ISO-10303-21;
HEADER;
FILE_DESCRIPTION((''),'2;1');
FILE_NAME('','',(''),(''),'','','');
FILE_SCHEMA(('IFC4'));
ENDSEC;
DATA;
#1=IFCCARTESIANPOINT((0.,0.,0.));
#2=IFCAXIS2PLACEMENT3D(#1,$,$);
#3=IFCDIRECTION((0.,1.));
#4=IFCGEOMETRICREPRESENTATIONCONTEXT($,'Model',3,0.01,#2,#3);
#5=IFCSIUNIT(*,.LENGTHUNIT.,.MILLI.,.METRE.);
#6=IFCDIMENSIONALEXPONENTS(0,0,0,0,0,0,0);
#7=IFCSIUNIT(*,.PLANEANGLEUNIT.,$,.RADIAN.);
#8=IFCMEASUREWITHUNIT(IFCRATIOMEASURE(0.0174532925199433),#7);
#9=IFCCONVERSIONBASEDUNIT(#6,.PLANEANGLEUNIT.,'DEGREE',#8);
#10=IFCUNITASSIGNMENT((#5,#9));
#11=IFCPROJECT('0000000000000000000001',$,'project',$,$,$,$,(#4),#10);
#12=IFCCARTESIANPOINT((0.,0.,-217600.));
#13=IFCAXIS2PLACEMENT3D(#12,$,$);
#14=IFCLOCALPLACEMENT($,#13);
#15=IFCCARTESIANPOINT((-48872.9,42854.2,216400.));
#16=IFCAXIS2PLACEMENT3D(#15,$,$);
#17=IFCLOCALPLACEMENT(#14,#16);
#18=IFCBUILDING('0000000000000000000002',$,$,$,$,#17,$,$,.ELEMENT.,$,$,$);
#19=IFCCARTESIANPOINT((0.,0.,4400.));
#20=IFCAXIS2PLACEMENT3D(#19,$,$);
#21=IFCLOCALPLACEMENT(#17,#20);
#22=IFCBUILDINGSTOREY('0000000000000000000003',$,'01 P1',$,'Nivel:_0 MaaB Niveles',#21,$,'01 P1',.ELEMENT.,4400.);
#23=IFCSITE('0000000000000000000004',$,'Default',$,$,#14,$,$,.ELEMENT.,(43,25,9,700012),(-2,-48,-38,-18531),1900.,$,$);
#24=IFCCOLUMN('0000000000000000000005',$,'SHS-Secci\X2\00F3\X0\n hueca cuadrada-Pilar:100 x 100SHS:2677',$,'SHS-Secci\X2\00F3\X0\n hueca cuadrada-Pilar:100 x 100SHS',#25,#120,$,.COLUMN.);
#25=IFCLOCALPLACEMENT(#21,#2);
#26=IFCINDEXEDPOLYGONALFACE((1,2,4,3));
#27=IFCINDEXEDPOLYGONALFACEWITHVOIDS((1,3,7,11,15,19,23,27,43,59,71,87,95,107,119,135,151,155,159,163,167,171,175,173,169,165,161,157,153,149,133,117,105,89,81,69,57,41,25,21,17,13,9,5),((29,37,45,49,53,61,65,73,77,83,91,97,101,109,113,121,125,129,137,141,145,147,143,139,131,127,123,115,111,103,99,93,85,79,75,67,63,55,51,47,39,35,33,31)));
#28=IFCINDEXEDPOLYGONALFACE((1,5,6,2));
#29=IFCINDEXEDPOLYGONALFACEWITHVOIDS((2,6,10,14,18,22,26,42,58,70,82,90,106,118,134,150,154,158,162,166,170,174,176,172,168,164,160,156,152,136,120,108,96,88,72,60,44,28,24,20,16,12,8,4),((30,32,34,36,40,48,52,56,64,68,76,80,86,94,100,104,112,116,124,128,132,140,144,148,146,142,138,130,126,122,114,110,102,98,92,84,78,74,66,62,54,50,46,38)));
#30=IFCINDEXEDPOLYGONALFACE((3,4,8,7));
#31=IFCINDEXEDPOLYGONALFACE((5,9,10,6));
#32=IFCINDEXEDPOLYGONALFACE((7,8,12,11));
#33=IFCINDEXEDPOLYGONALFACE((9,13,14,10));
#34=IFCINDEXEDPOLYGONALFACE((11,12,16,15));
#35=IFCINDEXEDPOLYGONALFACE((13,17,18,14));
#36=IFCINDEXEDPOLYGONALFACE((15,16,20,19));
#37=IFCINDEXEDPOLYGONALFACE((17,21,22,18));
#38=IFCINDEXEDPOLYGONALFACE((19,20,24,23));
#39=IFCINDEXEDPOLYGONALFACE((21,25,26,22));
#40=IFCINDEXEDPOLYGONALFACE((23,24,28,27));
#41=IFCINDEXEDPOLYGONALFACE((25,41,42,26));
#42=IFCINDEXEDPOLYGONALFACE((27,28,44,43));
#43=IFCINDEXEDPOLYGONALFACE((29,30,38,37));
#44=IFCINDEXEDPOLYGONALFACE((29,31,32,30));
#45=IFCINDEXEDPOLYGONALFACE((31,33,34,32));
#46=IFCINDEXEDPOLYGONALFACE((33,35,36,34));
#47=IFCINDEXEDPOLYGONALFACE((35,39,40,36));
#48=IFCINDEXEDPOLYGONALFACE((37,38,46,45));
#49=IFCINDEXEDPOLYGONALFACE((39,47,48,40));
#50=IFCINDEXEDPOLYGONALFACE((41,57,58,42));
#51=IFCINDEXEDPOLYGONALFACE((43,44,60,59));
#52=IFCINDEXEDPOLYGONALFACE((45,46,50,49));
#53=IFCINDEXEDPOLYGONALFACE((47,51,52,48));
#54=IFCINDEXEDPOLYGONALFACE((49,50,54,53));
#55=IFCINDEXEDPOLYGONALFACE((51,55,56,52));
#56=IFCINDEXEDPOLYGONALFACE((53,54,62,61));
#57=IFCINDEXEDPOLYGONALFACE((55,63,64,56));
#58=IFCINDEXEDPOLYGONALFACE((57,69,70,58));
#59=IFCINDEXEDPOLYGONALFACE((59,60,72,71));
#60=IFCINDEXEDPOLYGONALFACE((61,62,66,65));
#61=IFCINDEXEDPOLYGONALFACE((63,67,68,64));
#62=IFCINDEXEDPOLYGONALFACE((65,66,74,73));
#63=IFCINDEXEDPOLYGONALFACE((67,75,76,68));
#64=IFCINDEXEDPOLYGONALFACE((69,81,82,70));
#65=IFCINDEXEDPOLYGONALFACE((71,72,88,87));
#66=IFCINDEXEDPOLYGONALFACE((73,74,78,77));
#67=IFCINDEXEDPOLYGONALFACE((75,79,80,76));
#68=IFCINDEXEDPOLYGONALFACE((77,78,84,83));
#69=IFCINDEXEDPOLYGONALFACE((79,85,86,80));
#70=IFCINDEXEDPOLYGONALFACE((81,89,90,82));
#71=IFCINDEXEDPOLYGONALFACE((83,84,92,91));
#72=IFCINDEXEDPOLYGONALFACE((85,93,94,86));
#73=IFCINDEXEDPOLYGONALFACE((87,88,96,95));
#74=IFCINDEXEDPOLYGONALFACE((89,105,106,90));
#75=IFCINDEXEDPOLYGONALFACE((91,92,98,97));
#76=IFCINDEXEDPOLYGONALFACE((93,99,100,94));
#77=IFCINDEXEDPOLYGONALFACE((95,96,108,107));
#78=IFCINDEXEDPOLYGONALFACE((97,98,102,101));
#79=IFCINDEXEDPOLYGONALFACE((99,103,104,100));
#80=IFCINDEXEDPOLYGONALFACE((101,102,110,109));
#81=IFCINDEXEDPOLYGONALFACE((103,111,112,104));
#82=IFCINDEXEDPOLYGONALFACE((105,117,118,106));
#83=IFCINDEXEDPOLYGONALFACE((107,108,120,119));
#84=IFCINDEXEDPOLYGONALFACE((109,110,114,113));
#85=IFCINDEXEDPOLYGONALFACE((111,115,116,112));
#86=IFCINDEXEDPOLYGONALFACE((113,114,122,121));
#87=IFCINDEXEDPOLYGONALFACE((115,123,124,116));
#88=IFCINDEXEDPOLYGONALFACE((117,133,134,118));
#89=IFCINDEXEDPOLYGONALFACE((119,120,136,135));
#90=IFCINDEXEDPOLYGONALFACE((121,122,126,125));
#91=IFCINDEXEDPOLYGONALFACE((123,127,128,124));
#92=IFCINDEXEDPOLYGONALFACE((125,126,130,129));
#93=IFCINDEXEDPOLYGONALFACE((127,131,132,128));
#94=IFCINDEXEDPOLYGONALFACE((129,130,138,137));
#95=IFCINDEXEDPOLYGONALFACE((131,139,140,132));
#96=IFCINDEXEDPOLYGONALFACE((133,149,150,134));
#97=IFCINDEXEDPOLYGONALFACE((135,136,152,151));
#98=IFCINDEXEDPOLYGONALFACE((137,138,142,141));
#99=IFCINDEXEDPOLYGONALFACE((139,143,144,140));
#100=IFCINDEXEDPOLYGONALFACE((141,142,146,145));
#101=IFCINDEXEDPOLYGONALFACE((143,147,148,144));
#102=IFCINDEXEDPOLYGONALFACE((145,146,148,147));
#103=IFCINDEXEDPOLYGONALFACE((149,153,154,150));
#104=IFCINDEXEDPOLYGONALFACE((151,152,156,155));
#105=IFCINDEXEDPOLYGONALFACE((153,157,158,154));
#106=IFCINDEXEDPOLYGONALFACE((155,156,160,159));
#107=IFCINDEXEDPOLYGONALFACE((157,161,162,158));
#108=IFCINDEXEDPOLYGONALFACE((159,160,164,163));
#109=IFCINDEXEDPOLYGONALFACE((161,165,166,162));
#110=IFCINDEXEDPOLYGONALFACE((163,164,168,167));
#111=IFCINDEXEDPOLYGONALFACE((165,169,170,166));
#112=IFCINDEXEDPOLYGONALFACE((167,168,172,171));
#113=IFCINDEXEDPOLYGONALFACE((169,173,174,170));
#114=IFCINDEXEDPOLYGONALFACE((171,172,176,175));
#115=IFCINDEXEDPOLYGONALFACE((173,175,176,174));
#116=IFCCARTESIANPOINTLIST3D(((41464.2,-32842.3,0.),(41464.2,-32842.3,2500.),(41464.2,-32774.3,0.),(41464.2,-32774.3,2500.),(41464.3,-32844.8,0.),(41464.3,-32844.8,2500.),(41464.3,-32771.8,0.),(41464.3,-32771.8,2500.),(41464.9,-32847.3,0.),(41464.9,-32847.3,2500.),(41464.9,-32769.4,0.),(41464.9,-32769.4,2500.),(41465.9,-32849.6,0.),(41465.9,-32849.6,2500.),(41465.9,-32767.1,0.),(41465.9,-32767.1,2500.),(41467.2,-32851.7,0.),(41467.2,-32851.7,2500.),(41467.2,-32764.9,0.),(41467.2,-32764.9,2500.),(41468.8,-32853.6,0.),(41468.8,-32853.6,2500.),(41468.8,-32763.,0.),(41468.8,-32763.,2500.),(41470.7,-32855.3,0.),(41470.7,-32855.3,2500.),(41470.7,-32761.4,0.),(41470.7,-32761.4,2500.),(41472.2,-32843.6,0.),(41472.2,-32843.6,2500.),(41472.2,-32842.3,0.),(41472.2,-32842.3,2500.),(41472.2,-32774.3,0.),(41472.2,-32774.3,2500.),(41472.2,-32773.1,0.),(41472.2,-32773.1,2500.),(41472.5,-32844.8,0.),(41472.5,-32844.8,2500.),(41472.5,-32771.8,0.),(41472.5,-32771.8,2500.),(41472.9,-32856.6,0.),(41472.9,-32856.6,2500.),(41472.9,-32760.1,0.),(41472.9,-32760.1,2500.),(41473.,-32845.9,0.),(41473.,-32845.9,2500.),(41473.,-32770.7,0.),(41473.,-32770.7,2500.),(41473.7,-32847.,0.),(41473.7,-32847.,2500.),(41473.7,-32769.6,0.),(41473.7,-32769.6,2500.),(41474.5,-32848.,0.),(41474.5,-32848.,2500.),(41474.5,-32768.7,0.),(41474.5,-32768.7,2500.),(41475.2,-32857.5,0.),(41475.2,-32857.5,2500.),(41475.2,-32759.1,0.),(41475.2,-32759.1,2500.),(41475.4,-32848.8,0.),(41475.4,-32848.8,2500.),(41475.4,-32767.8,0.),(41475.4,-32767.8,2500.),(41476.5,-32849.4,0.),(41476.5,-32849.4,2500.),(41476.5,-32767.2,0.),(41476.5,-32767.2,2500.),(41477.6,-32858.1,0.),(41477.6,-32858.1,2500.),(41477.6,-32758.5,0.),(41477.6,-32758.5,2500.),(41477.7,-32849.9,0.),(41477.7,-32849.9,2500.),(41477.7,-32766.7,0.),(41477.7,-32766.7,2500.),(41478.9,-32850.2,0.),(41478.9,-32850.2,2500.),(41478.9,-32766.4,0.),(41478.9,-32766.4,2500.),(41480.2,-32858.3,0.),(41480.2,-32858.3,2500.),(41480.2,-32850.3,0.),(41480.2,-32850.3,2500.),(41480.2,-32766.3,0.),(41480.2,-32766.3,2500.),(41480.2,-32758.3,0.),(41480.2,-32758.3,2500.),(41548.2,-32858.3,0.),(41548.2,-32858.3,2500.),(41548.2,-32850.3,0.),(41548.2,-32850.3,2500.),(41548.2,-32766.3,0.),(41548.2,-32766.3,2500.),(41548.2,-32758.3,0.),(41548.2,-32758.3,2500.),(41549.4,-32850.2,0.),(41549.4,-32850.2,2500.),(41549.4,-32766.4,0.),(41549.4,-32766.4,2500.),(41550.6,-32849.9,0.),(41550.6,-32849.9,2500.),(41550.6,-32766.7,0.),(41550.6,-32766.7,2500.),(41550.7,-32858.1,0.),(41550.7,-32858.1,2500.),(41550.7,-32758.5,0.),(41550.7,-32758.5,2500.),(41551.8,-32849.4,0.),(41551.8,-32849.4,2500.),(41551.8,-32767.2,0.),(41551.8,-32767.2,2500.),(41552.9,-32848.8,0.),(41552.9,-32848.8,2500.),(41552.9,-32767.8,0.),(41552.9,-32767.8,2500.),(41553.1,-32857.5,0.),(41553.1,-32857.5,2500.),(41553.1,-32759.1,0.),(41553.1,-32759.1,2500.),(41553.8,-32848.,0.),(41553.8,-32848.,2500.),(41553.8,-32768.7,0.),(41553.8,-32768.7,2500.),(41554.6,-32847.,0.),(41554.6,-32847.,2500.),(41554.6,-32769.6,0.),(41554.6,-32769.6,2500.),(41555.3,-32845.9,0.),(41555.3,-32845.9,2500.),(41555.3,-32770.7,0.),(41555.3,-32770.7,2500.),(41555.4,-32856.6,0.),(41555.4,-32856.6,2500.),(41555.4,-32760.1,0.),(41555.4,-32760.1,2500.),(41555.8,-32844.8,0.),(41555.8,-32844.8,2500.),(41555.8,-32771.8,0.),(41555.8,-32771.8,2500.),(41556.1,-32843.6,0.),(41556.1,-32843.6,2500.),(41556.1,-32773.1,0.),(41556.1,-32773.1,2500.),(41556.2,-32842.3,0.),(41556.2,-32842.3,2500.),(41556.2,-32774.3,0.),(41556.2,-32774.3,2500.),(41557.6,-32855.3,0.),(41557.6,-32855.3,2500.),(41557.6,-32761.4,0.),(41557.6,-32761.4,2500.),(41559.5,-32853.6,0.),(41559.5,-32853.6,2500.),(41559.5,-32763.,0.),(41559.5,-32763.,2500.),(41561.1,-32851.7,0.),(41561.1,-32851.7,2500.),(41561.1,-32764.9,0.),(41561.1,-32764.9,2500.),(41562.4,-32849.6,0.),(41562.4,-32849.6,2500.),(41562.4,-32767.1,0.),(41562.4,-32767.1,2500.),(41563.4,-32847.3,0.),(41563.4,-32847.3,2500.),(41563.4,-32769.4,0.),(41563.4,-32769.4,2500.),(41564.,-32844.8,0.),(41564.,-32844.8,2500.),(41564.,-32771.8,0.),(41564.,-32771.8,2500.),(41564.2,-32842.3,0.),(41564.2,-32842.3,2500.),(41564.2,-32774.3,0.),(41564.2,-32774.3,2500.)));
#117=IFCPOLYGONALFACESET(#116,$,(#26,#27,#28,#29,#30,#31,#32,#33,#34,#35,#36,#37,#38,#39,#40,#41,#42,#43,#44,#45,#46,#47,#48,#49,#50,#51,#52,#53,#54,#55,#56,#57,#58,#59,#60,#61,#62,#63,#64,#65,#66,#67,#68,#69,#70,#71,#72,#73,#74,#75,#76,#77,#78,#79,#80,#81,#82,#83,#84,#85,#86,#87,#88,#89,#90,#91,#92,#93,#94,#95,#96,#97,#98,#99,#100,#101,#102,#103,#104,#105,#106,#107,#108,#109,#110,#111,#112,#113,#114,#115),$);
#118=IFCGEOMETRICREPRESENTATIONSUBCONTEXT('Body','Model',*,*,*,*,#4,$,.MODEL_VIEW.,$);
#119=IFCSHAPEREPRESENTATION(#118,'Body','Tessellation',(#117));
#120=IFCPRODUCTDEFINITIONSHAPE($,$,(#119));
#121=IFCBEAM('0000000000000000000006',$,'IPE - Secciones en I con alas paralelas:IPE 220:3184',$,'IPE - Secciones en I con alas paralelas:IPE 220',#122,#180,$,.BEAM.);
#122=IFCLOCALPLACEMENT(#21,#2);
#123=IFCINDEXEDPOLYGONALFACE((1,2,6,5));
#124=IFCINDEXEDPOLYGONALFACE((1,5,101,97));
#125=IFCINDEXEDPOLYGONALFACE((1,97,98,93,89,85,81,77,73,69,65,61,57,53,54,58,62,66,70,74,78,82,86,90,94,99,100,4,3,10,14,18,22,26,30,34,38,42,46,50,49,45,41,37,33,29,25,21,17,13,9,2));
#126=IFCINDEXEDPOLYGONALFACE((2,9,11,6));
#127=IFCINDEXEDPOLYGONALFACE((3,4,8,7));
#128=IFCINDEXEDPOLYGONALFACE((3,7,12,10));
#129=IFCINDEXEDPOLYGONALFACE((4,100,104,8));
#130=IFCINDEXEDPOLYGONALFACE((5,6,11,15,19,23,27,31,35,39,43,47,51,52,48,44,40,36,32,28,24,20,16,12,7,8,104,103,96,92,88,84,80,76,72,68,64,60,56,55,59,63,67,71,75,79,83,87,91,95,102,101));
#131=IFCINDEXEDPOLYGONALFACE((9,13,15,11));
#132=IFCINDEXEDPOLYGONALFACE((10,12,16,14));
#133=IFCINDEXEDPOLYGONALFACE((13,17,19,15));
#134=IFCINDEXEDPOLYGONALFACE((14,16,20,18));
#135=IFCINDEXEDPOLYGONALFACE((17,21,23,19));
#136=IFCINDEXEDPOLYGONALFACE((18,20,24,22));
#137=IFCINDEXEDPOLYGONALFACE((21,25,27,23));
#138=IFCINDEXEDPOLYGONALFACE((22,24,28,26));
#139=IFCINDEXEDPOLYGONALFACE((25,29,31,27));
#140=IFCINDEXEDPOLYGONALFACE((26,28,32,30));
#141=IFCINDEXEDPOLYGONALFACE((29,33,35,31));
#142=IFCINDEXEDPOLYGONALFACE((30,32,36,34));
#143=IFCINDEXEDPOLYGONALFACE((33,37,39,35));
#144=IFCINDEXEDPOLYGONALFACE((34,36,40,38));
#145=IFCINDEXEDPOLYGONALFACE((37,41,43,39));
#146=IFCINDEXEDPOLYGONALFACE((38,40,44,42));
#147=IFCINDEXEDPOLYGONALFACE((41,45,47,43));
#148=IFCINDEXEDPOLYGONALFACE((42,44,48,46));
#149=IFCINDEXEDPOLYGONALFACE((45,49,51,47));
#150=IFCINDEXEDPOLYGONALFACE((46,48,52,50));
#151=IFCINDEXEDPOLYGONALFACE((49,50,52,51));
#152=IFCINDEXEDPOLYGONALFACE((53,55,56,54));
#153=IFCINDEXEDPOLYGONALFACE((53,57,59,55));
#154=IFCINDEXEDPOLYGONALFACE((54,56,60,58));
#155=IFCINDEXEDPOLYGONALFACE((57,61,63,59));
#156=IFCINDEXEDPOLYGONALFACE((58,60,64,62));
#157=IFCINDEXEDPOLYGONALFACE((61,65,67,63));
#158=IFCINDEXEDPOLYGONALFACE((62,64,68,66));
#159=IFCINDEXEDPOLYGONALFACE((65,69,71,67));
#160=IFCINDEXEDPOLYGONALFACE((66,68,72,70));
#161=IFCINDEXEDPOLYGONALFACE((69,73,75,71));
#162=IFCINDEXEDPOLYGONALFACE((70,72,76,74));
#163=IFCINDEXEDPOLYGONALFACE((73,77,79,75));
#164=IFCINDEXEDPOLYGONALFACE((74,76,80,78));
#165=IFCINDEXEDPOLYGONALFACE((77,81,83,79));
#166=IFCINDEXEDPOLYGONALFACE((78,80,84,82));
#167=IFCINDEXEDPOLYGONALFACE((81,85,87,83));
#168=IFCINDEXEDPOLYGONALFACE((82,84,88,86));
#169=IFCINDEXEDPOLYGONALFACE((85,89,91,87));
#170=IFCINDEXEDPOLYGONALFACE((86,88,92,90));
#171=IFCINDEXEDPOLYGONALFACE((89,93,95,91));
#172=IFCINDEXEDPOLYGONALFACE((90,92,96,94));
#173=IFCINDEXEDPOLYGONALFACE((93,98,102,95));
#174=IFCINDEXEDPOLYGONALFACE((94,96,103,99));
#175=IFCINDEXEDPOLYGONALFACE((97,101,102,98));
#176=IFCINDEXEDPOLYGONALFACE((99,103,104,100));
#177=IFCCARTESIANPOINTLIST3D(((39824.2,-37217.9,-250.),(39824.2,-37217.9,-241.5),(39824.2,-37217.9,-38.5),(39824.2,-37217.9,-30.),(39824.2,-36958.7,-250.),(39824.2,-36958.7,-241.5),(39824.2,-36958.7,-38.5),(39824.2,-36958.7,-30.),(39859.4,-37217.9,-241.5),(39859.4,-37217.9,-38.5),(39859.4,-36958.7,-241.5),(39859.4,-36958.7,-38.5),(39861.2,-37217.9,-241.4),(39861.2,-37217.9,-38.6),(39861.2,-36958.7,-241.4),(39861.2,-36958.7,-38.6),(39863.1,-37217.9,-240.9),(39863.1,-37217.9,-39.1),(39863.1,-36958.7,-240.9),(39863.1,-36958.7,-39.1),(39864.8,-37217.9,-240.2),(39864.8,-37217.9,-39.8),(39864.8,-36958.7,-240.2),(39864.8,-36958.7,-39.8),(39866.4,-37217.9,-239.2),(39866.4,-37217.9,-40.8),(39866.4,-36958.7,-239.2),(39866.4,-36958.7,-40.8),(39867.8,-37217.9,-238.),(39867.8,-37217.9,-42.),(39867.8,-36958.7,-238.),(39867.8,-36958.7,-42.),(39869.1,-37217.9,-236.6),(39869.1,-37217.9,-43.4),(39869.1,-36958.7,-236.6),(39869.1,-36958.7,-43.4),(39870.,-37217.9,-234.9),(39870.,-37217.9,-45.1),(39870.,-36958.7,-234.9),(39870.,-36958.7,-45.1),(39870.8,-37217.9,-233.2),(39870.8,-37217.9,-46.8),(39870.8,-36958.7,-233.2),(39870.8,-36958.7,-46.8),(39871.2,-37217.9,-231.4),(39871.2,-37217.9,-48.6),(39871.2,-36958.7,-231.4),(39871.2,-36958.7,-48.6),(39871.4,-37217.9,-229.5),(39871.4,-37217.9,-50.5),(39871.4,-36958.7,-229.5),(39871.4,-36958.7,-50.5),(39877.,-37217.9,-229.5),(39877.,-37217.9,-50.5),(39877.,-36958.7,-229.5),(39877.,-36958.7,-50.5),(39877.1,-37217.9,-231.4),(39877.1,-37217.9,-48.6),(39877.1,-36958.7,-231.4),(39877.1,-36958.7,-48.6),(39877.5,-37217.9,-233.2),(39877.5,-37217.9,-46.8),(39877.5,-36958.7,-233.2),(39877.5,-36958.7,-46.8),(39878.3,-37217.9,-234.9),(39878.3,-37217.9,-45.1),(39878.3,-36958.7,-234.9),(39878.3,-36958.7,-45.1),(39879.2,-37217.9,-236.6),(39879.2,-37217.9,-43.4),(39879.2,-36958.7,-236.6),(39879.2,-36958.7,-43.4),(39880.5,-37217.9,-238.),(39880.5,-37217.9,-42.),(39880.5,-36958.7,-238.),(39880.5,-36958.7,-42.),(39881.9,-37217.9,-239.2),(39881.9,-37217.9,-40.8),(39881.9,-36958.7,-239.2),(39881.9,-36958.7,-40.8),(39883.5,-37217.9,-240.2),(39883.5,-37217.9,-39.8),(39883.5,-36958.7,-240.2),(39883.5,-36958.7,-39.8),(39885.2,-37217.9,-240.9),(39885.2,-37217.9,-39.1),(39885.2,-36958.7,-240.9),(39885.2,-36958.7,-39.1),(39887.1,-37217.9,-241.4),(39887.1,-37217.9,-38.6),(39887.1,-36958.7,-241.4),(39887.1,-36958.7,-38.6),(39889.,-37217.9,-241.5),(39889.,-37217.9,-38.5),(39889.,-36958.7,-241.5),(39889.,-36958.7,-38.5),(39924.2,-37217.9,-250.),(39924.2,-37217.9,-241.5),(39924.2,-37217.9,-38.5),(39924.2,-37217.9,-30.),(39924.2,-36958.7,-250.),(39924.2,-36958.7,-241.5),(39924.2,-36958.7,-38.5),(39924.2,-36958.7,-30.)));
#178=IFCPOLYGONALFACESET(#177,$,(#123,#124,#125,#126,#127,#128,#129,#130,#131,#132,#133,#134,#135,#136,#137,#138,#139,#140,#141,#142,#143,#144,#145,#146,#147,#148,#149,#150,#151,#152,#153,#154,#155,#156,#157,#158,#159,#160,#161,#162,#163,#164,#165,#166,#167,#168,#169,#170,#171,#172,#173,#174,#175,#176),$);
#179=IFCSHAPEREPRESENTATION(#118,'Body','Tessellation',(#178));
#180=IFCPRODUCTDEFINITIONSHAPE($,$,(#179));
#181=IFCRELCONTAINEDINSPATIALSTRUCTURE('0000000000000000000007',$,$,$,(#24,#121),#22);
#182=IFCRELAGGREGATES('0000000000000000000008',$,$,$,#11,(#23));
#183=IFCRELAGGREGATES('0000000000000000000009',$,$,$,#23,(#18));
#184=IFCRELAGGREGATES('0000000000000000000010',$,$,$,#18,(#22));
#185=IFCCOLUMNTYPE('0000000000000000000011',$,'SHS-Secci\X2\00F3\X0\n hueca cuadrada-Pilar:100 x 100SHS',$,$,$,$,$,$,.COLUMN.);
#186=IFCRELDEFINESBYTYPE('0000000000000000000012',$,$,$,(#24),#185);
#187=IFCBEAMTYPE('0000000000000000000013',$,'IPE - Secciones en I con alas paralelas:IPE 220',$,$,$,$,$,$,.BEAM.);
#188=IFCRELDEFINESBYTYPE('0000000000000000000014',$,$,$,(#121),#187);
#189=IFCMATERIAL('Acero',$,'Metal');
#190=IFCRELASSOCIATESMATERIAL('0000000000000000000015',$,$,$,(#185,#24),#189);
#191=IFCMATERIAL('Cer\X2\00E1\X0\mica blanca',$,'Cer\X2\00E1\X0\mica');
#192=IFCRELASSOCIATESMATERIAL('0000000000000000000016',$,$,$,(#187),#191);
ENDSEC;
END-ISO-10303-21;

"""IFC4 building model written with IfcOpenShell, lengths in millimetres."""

from ifc_helpers import new_model, entity, si_unit, converted_unit, direction, frame, origin, place, context, subcontext, project, spatial, indexed_curve, outline, extrude, source, transform, mapped, material, type_object, type_shapes, element, save


model = new_model("IFC4")

# Units and contexts
model_context = context("Model", 3, precision=0.01, world=origin(), true_north=direction((0.0, 1.0)))
body_context = subcontext(model_context, "Body", "Model", "MODEL_VIEW")
ifc_project = project(units=[si_unit("LENGTHUNIT", "METRE", prefix="MILLI"), converted_unit("PLANEANGLEUNIT", "DEGREE", entity("IfcRatioMeasure", 0.0174532925199433), si_unit("PLANEANGLEUNIT", "RADIAN"), dimensions=[0, 0, 0, 0, 0, 0, 0])], contexts=[model_context])

# Site, building, storey
site_placement = place(None, frame((0.0, 0.0, -217600.0)))
site = spatial("IfcSite", under=ifc_project, at=site_placement, Name="Default", CompositionType="ELEMENT", RefLatitude=(43, 25, 9, 700012), RefLongitude=(-2, -48, -38, -18531), RefElevation=1900.0)
building_placement = place(site_placement, frame((-48872.9, 42854.2, 216400.0)))
building = spatial("IfcBuilding", under=site, at=building_placement, CompositionType="ELEMENT")
storey_placement = place(building_placement, frame((0.0, 0.0, 4400.0)))
storey = spatial("IfcBuildingStorey", under=building, at=storey_placement, Name="01 P1", ObjectType="Nivel:_0 MaaB Niveles", LongName="01 P1", CompositionType="ELEMENT", Elevation=4400.0)

# Column
ifc_material_1 = material(Name="Acero", Category="Metal")
column_type_1 = type_object("IfcColumnType", Name="SHS-Sección hueca cuadrada-Pilar:100 x 100SHS", PredefinedType="COLUMN", material=ifc_material_1)
shared_shape_1 = source(origin(), body_context, "Body", "SweptSolid", [
    extrude(outline(indexed_curve([(-34.0, -50.0), (34.0, -50.0), (36.5, -49.8), (38.9, -49.2), (41.3, -48.3), (43.4, -46.9), (45.3, -45.3), (46.9, -43.4), (48.3, -41.3), (49.2, -38.9), (49.8, -36.5), (50.0, -34.0), (50.0, 34.0), (49.8, 36.5), (49.2, 38.9), (48.3, 41.3), (46.9, 43.4), (45.3, 45.3), (43.4, 46.9), (41.3, 48.3), (38.9, 49.2), (36.5, 49.8), (34.0, 50.0), (-34.0, 50.0), (-36.5, 49.8), (-38.9, 49.2), (-41.3, 48.3), (-43.4, 46.9), (-45.3, 45.3), (-46.9, 43.4), (-48.3, 41.3), (-49.2, 38.9), (-49.8, 36.5), (-50.0, 34.0), (-50.0, -34.0), (-49.8, -36.5), (-49.2, -38.9), (-48.3, -41.3), (-46.9, -43.4), (-45.3, -45.3), (-43.4, -46.9), (-41.3, -48.3), (-38.9, -49.2), (-36.5, -49.8), (-34.0, -50.0)], self_intersect=False), holes=[indexed_curve([(-42.0, 34.0), (-41.9, 35.3), (-41.6, 36.5), (-41.1, 37.6), (-40.5, 38.7), (-39.7, 39.7), (-38.7, 40.5), (-37.6, 41.1), (-36.5, 41.6), (-35.3, 41.9), (-34.0, 42.0), (34.0, 42.0), (35.3, 41.9), (36.5, 41.6), (37.6, 41.1), (38.7, 40.5), (39.7, 39.7), (40.5, 38.7), (41.1, 37.6), (41.6, 36.5), (41.9, 35.3), (42.0, 34.0), (42.0, -34.0), (41.9, -35.3), (41.6, -36.5), (41.1, -37.6), (40.5, -38.7), (39.7, -39.7), (38.7, -40.5), (37.6, -41.1), (36.5, -41.6), (35.3, -41.9), (34.0, -42.0), (-34.0, -42.0), (-35.3, -41.9), (-36.5, -41.6), (-37.6, -41.1), (-38.7, -40.5), (-39.7, -39.7), (-40.5, -38.7), (-41.1, -37.6), (-41.6, -36.5), (-41.9, -35.3), (-42.0, -34.0), (-42.0, 34.0)], self_intersect=False)]), frame((0.0, 0.0, 4400.0), z_axis=(0.0, 0.0, 1.0), x_axis=(0.0, 1.0, 0.0)), (0.0, 0.0, 1.0), 2500.0),
])
type_shapes(column_type_1, [shared_shape_1])
column_1_placement = place(storey_placement, frame((41514.2, -32808.3, -4400.0), z_axis=(0.0, 0.0, 1.0), x_axis=(0.0, -1.0, 0.0)))
element("IfcColumn", 1, at=column_1_placement, inside=storey, type_object=column_type_1, material=ifc_material_1, Name="SHS-Sección hueca cuadrada-Pilar:100 x 100SHS:2677", ObjectType="SHS-Sección hueca cuadrada-Pilar:100 x 100SHS", PredefinedType="COLUMN", context=body_context, shape_type="MappedRepresentation", body=[
    mapped(shared_shape_1, transform((0.0, 0.0, 0.0), scale=1.0)),
])

# Beam
ifc_material_2 = material(Name="Cerámica blanca", Category="Cerámica")
beam_type = type_object("IfcBeamType", Name="IPE - Secciones en I con alas paralelas:IPE 220", PredefinedType="BEAM", material=ifc_material_2)
shared_shape_2 = source(origin(), body_context, "Body", "SweptSolid", [
    extrude(outline(indexed_curve([(-110.0, -50.0), (-101.5, -50.0), (-101.5, -14.8), (-101.4, -12.9), (-100.9, -11.1), (-100.2, -9.4), (-99.2, -7.7), (-98.0, -6.3), (-96.6, -5.1), (-94.9, -4.1), (-93.2, -3.4), (-91.4, -2.9), (-89.5, -2.8), (89.5, -2.8), (91.4, -2.9), (93.2, -3.4), (94.9, -4.1), (96.6, -5.1), (98.0, -6.3), (99.2, -7.7), (100.2, -9.4), (100.9, -11.1), (101.4, -12.9), (101.5, -14.8), (101.5, -50.0), (110.0, -50.0), (110.0, 50.0), (101.5, 50.0), (101.5, 14.8), (101.4, 12.9), (100.9, 11.1), (100.2, 9.4), (99.2, 7.7), (98.0, 6.3), (96.6, 5.1), (94.9, 4.1), (93.2, 3.4), (91.4, 2.9), (89.5, 2.8), (-89.5, 2.8), (-91.4, 2.9), (-93.2, 3.4), (-94.9, 4.1), (-96.6, 5.1), (-98.0, 6.3), (-99.2, 7.7), (-100.2, 9.4), (-100.9, 11.1), (-101.4, 12.9), (-101.5, 14.8), (-101.5, 50.0), (-110.0, 50.0), (-110.0, -50.0)], self_intersect=False)), frame((-41.7, 0.0, 0.0), z_axis=(1.0, 0.0, 0.0), x_axis=(0.0, 0.0, -1.0)), (0.0, 0.0, 1.0), 259.2),
])
type_shapes(beam_type, [shared_shape_2])
beam_placement = place(storey_placement, frame((39874.2, -37176.2, -140.0), z_axis=(0.0, 0.0, 1.0), x_axis=(0.0, 1.0, 0.0)))
element("IfcBeam", 2, at=beam_placement, inside=storey, type_object=beam_type, Name="IPE - Secciones en I con alas paralelas:IPE 220:3184", ObjectType="IPE - Secciones en I con alas paralelas:IPE 220", PredefinedType="BEAM", context=body_context, shape_type="MappedRepresentation", body=[
    mapped(shared_shape_2, transform((0.0, 0.0, 0.0), scale=1.0)),
])

save(model, "model.ifc")
